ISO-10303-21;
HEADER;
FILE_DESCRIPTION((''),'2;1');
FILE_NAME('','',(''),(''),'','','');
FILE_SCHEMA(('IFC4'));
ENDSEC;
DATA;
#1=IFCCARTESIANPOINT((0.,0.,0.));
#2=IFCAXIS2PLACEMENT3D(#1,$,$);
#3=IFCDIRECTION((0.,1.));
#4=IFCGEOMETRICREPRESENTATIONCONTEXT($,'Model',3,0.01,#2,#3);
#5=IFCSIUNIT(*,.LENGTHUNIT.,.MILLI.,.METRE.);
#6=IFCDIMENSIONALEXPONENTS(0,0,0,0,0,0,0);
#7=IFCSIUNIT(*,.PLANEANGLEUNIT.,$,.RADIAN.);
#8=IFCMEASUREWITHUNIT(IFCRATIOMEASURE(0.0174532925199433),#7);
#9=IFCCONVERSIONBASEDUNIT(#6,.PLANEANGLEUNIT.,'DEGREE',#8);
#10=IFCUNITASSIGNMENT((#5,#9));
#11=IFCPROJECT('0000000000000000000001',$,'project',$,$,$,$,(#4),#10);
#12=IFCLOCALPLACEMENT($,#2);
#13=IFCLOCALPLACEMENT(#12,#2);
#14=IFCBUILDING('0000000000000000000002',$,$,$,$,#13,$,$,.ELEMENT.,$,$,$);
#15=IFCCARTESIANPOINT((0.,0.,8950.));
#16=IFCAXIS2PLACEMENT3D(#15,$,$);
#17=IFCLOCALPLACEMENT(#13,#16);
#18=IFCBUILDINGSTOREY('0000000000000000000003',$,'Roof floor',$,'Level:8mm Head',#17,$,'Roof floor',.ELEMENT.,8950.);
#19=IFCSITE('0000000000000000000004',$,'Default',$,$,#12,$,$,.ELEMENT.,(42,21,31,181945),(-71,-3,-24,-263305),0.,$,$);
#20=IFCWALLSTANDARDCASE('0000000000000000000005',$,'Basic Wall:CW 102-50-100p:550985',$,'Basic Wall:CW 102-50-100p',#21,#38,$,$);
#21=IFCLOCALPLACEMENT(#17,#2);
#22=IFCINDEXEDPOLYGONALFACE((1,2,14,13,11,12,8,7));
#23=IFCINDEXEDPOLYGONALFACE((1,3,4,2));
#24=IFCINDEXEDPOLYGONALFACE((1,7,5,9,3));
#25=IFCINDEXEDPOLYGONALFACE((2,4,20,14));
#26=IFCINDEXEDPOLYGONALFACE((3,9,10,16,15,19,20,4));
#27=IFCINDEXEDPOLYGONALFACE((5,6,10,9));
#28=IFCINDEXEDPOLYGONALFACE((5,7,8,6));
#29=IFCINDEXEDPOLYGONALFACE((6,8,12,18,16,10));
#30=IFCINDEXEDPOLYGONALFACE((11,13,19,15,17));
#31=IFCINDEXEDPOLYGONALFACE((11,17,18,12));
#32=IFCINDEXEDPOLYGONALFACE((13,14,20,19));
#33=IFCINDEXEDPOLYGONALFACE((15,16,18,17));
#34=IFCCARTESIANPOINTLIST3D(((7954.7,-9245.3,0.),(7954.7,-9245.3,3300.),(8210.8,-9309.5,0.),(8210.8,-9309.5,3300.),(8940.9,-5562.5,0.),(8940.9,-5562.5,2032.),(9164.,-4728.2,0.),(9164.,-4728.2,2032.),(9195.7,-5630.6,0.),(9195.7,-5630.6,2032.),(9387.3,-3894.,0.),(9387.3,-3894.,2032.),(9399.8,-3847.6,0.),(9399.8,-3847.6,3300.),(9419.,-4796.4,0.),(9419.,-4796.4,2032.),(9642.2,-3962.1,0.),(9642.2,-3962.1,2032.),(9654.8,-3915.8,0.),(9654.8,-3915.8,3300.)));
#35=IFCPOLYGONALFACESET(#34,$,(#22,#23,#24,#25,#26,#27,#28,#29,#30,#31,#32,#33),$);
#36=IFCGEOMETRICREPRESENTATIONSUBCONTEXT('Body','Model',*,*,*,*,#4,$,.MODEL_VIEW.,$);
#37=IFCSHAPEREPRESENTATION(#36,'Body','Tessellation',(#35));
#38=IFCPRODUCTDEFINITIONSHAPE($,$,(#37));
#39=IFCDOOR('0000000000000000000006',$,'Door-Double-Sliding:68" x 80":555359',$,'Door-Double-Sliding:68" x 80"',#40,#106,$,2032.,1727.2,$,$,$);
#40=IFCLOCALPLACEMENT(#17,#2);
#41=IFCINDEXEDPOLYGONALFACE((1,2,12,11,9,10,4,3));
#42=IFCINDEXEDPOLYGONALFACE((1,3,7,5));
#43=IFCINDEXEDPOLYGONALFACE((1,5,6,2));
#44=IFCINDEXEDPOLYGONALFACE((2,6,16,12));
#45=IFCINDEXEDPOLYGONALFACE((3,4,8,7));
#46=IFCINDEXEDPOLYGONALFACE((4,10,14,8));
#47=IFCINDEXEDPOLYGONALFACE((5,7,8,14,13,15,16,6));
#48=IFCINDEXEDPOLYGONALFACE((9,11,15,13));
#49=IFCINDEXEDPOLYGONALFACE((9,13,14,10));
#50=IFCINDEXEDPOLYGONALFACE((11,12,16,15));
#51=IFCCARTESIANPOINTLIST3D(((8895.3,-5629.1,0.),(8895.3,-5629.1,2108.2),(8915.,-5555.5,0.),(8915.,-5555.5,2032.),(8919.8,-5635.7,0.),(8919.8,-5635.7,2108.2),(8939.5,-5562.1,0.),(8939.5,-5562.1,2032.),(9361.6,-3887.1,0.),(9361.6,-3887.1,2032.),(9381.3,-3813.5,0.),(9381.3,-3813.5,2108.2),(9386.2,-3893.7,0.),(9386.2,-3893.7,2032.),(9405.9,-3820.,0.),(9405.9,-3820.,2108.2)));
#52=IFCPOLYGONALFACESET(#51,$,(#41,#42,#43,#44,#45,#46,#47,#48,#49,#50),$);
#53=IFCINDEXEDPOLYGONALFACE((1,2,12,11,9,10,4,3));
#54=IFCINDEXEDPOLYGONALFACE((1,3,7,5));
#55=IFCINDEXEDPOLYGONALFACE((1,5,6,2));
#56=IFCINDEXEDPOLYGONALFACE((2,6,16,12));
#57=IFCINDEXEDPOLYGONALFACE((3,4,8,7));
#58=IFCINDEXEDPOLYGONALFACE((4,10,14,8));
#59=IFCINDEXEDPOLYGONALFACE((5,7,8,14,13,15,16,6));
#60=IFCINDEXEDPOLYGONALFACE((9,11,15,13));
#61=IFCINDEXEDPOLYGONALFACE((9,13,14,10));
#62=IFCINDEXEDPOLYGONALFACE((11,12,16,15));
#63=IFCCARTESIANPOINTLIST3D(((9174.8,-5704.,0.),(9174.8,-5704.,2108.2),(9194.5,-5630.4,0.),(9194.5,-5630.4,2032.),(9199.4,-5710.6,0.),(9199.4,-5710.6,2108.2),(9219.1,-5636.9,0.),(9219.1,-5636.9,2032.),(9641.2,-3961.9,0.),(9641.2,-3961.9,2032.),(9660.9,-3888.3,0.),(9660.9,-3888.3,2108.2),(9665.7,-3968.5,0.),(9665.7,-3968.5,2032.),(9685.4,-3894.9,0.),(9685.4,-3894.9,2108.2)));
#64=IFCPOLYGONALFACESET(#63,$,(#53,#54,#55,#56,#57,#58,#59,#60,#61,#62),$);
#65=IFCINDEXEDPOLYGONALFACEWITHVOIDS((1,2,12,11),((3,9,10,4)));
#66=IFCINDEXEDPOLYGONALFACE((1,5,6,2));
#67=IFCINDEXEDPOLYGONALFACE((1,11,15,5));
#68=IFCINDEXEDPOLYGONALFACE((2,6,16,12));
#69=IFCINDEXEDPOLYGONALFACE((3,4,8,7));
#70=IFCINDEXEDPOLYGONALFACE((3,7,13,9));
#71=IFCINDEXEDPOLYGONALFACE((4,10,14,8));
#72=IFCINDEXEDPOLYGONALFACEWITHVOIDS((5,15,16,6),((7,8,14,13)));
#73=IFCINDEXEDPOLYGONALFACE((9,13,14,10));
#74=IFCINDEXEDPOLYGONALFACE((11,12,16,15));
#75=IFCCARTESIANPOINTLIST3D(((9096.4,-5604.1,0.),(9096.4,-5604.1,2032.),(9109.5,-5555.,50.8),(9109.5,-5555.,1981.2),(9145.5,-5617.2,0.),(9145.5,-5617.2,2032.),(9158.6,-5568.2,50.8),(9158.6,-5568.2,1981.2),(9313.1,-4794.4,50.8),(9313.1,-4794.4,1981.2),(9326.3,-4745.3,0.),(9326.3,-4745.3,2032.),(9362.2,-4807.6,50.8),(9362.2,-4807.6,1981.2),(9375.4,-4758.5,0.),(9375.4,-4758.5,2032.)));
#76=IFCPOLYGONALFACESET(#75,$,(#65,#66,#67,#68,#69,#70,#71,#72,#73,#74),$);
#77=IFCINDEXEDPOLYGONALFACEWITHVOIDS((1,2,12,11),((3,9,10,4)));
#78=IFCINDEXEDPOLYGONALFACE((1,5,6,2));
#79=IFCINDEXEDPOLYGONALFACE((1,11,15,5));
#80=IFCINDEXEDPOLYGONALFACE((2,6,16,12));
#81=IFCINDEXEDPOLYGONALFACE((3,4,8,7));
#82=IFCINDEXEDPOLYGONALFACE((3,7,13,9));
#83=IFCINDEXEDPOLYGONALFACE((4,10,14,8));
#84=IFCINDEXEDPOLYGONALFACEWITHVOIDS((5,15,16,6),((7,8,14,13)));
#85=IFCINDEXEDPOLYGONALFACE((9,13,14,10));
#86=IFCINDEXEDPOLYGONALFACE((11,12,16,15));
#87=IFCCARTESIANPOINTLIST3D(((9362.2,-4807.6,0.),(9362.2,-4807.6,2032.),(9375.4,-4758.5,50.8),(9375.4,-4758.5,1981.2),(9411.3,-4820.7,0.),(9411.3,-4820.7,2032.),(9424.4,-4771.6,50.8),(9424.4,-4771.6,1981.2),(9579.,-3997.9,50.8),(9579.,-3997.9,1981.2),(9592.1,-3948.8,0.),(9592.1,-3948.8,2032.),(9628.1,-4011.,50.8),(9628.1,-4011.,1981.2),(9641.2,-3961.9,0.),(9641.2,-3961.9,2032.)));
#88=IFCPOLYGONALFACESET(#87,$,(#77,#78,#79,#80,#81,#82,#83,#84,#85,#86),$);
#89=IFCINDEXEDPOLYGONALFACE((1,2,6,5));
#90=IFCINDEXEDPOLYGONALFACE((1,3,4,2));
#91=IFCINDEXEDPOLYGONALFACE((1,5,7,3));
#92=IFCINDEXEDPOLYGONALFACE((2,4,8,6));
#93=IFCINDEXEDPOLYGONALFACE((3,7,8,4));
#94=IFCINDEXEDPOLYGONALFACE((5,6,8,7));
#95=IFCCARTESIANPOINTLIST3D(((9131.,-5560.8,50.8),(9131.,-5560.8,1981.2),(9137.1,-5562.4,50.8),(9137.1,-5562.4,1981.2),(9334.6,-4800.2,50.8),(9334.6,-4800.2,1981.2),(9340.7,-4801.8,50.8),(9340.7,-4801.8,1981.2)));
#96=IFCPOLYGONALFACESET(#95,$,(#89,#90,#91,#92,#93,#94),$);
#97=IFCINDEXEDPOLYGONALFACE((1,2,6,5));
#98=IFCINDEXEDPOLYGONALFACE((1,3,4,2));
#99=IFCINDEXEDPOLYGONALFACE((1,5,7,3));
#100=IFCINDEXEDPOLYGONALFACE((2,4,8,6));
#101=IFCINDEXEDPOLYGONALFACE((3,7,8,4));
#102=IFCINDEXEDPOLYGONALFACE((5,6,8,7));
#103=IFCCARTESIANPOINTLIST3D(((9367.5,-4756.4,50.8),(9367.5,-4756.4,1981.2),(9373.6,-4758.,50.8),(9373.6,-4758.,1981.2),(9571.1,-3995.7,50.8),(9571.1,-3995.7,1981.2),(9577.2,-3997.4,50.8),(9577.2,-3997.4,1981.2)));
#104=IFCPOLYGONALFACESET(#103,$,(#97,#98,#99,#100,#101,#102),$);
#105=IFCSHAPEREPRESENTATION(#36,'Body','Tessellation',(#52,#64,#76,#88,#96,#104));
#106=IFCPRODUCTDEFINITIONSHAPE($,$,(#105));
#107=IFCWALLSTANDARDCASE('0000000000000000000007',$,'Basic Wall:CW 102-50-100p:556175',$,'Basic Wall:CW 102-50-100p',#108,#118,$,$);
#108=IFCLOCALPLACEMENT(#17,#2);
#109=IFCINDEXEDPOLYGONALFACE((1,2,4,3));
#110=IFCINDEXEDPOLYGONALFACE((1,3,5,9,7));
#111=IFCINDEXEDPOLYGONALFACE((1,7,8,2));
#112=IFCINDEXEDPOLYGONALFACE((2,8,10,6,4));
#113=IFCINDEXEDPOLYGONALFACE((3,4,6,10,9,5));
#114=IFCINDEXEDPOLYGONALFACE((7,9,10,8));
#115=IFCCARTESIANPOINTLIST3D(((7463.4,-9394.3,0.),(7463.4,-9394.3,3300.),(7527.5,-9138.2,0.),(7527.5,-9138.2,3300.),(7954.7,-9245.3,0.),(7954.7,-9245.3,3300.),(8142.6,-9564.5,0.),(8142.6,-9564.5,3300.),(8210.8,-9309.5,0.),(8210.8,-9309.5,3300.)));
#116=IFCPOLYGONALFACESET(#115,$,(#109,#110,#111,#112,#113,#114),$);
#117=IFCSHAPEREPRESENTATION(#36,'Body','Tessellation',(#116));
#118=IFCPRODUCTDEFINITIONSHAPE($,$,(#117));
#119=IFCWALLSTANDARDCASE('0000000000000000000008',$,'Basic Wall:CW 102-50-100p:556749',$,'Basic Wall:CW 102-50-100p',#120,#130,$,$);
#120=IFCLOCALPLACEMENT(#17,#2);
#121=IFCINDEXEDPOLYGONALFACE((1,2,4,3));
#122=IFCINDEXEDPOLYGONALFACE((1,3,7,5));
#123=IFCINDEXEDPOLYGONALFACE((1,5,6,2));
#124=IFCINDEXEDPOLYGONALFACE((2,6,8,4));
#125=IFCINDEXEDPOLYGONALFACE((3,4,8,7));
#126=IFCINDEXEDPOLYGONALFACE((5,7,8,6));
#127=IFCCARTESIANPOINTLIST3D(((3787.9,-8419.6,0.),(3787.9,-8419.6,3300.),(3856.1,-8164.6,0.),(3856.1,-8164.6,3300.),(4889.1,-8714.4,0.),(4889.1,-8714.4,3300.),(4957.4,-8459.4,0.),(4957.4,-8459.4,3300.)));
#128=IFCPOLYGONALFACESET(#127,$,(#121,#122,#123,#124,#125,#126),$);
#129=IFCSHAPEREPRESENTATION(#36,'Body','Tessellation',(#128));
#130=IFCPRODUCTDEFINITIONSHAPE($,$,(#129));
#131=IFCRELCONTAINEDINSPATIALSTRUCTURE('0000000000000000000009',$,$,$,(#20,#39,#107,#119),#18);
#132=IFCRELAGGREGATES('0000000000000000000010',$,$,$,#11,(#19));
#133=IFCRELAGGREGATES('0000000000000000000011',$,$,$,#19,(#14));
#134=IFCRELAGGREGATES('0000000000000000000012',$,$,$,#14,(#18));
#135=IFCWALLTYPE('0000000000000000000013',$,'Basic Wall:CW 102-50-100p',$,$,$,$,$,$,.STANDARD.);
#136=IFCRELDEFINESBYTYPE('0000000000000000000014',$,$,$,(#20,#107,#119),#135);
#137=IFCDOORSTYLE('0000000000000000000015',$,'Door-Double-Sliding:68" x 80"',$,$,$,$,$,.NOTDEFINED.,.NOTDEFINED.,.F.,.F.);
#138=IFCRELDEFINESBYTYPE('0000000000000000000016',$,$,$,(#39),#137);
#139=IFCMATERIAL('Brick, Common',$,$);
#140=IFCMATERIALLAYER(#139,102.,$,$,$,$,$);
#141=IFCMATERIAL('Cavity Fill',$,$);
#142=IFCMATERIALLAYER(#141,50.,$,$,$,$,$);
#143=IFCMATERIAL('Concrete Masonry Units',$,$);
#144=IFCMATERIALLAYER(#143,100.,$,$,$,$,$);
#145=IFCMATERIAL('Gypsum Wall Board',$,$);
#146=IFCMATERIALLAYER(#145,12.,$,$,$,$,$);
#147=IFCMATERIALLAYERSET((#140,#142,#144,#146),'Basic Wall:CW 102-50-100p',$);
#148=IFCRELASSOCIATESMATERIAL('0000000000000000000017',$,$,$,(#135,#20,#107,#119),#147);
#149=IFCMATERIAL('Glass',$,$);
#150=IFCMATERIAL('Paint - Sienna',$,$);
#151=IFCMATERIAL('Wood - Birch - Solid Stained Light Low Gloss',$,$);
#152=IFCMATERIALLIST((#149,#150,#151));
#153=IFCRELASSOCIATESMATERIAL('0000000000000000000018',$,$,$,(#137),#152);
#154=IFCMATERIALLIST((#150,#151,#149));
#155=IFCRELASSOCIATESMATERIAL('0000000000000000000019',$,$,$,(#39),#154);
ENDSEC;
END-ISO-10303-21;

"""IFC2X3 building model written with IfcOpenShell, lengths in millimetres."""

from ifc_helpers import new_model, entity, si_unit, converted_unit, direction, frame, frame_2d, origin, origin_2d_with_axis, place, context, subcontext, project, spatial, polyline, rectangle, outline, extrude, source, transform, mapped, material, material_list, layer, layer_set, layer_usage, type_object, type_shapes, element, fill, save


model = new_model("IFC2X3")

# Units and contexts
model_context = context("Model", 3, precision=0.01, world=origin(), true_north=direction((0.0, 1.0)))
body_context = subcontext(model_context, "Body", "Model", "MODEL_VIEW")
ifc_project = project(units=[si_unit("LENGTHUNIT", "METRE", prefix="MILLI"), converted_unit("PLANEANGLEUNIT", "DEGREE", entity("IfcRatioMeasure", 0.0174532925199433), si_unit("PLANEANGLEUNIT", "RADIAN"), dimensions=[0, 0, 0, 0, 0, 0, 0])], contexts=[model_context])

# Site, building, storey
site_placement = place(None, origin())
site = spatial("IfcSite", under=ifc_project, at=site_placement, Name="Default", CompositionType="ELEMENT", RefLatitude=(42, 21, 31, 181945), RefLongitude=(-71, -3, -24, -263305), RefElevation=0.0)
building_placement = place(site_placement, origin())
building = spatial("IfcBuilding", under=site, at=building_placement, CompositionType="ELEMENT")
storey_placement = place(building_placement, frame((0.0, 0.0, 8950.0)))
storey = spatial("IfcBuildingStorey", under=building, at=storey_placement, Name="Roof floor", ObjectType="Level:8mm Head", LongName="Roof floor", CompositionType="ELEMENT", Elevation=8950.0)

# Shared definitions
ifc_material_1 = material(Name="Glass")

# Shared definitions
ifc_material_2 = material(Name="Brick, Common")
ifc_layer_1 = layer(ifc_material_2, 102.0)
ifc_material_3 = material(Name="Cavity Fill")
ifc_layer_2 = layer(ifc_material_3, 50.0)
ifc_material_4 = material(Name="Concrete Masonry Units")
ifc_layer_3 = layer(ifc_material_4, 100.0)
ifc_material_5 = material(Name="Gypsum Wall Board")
ifc_layer_4 = layer(ifc_material_5, 12.0)
ifc_layer_set = layer_set([ifc_layer_1, ifc_layer_2, ifc_layer_3, ifc_layer_4], Name="Basic Wall:CW 102-50-100p")
wall_type = type_object("IfcWallType", Name="Basic Wall:CW 102-50-100p", PredefinedType="STANDARD", material=ifc_layer_set)

# Wall, opening, door
ifc_layer_usage_1 = layer_usage(ifc_layer_set, "AXIS2", "POSITIVE", -132.0)
wall_1_placement = place(storey_placement, frame((8082.2, -9279.4, 0.0), z_axis=(0.0, 0.0, 1.0), x_axis=(0.258607, 0.965983, 0.0)))
wall_1 = element("IfcWallStandardCase", 1, at=wall_1_placement, inside=storey, type_object=wall_type, material=ifc_layer_usage_1, Name="Basic Wall:CW 102-50-100p:550985", ObjectType="Basic Wall:CW 102-50-100p", context=body_context, shape_type="SweptSolid", body=[
    extrude(outline(polyline([(4.2, -132.0), (5587.8, -132.0), (5587.8, 132.0), (0.0, 132.0), (4.2, -132.0)])), origin(), (0.0, 0.0, 1.0), 3300.0),
])
opening_placement = place(wall_1_placement, frame((5539.8, 132.2, 0.0)))
opening = element("IfcOpeningElement", 2, at=opening_placement, cuts=wall_1, ObjectType="Opening", context=body_context, shape_type="SweptSolid", body=[
    extrude(rectangle(XDim=2032.0, YDim=1727.2, at=frame_2d((1016.0, 863.6), x_axis=(-1.0, 0.0))), frame((0.0, 0.0, 0.0), z_axis=(0.00022, -1.0, 0.0), x_axis=(0.0, 0.0, 1.0)), (0.0, 0.0, 1.0), 264.0),
])
ifc_material_6 = material(Name="Paint - Sienna")
ifc_material_7 = material(Name="Wood - Birch - Solid Stained Light Low Gloss")
ifc_material_list_1 = material_list([ifc_material_6, ifc_material_7, ifc_material_1])
ifc_material_list_2 = material_list([ifc_material_1, ifc_material_6, ifc_material_7])
door_style = type_object("IfcDoorStyle", Name="Door-Double-Sliding:68\" x 80\"", ConstructionType="NOTDEFINED", OperationType="NOTDEFINED", ParameterTakesPrecedence=False, Sizeable=False, material=ifc_material_list_2)
shared_shape_1 = source(origin(), body_context, "Body", "SweptSolid", [
    extrude(outline(polyline([(-1035.0, -939.8), (1073.2, -939.8), (1073.2, 939.8), (-1035.0, 939.8), (-1035.0, 863.6), (996.9, 863.6), (996.9, -863.6), (-1035.0, -863.6), (-1035.0, -939.8)])), frame((863.6, -25.4, 1035.0), z_axis=(0.0, 1.0, 0.0), x_axis=(0.0, 0.0, 1.0)), (0.0, 0.0, 1.0), 25.4),
    extrude(outline(polyline([(-939.8, -1035.0), (-863.6, -1035.0), (-863.6, 997.0), (863.6, 997.0), (863.6, -1035.0), (939.8, -1035.0), (939.8, 1073.2), (-939.8, 1073.2), (-939.8, -1035.0)])), frame((863.6, 264.0, 1035.0), z_axis=(0.0, 1.0, 0.0), x_axis=(-1.0, 0.0, 0.0)), (0.0, 0.0, 1.0), 25.4),
    extrude(outline(polyline([(-444.5, -1016.0), (444.5, -1016.0), (444.5, 1016.0), (-444.5, 1016.0), (-444.5, -1016.0)]), holes=[polyline([(-393.7, -965.2), (-393.7, 965.2), (393.7, 965.2), (393.7, -965.2), (-393.7, -965.2)])]), frame((1282.7, 162.4, 1016.0), z_axis=(0.0, 1.0, 0.0), x_axis=(1.0, 0.0, 0.0)), (0.0, 0.0, 1.0), 50.8),
    extrude(outline(polyline([(-1016.0, -444.5), (1016.0, -444.5), (1016.0, 444.5), (-1016.0, 444.5), (-1016.0, -444.5)]), holes=[polyline([(-965.2, -393.7), (-965.2, 393.7), (965.2, 393.7), (965.2, -393.7), (-965.2, -393.7)])]), frame((444.5, 213.2, 1016.0), z_axis=(0.0, 1.0, 0.0), x_axis=(0.0, 0.0, -1.0)), (0.0, 0.0, 1.0), 50.8),
    extrude(rectangle(XDim=6.3, YDim=787.4, at=origin_2d_with_axis()), frame((1282.7, 187.8, 50.8), z_axis=(0.0, 0.0, 1.0), x_axis=(0.0, -1.0, 0.0)), (0.0, 0.0, 1.0), 1930.4),
    extrude(rectangle(XDim=6.4, YDim=787.4, at=frame_2d((0.0, 0.0), x_axis=(1.0, 0.0))), frame((444.5, 208.2, 50.8), z_axis=(0.0, 0.0, 1.0), x_axis=(0.0, 1.0, 0.0)), (0.0, 0.0, 1.0), 1930.4),
])
type_shapes(door_style, [shared_shape_1])
door_placement = place(opening_placement, frame((0.0, 1.0, 0.0), z_axis=(0.0, 0.0, 1.0), x_axis=(-1.0, 0.0, 0.0)))
door = element("IfcDoor", 3, at=door_placement, inside=storey, type_object=door_style, material=ifc_material_list_1, Name="Door-Double-Sliding:68\" x 80\":555359", ObjectType="Door-Double-Sliding:68\" x 80\"", OverallHeight=2032.0, OverallWidth=1727.2, context=body_context, shape_type="MappedRepresentation", body=[
    mapped(shared_shape_1, transform((0.0, 0.0, 0.0), scale=1.0)),
])
fill(opening, door)

# Walls
ifc_layer_usage_2 = layer_usage(ifc_layer_set, "AXIS2", "POSITIVE", -132.0)
wall_2_placement = place(storey_placement, frame((7495.5, -9266.3, 0.0), z_axis=(0.0, 0.0, 1.0), x_axis=(0.970003, -0.243092, 0.0)))
element("IfcWallStandardCase", 4, at=wall_2_placement, inside=storey, type_object=wall_type, material=ifc_layer_usage_2, Name="Basic Wall:CW 102-50-100p:556175", ObjectType="Basic Wall:CW 102-50-100p", context=body_context, shape_type="SweptSolid", body=[
    extrude(outline(polyline([(700.2, -132.0), (704.4, 132.0), (440.4, 132.0), (0.0, 132.0), (0.0, -132.0), (700.2, -132.0)])), origin(), (0.0, 0.0, 1.0), 3300.0),
])
ifc_layer_usage_3 = layer_usage(ifc_layer_set, "AXIS2", "NEGATIVE", 132.0)
wall_3_placement = place(storey_placement, frame((3822.0, -8292.1, 0.0), z_axis=(0.0, 0.0, 1.0), x_axis=(0.965983, -0.258607, 0.0)))
element("IfcWallStandardCase", 5, at=wall_3_placement, inside=storey, type_object=wall_type, material=ifc_layer_usage_3, Name="Basic Wall:CW 102-50-100p:556749", ObjectType="Basic Wall:CW 102-50-100p", context=body_context, shape_type="SweptSolid", body=[
    extrude(rectangle(XDim=1140.0, YDim=264.0, at=frame_2d((570.0, 0.0), x_axis=(-1.0, 0.0))), origin(), (0.0, 0.0, 1.0), 3300.0),
])

save(model, "model.ifc")
